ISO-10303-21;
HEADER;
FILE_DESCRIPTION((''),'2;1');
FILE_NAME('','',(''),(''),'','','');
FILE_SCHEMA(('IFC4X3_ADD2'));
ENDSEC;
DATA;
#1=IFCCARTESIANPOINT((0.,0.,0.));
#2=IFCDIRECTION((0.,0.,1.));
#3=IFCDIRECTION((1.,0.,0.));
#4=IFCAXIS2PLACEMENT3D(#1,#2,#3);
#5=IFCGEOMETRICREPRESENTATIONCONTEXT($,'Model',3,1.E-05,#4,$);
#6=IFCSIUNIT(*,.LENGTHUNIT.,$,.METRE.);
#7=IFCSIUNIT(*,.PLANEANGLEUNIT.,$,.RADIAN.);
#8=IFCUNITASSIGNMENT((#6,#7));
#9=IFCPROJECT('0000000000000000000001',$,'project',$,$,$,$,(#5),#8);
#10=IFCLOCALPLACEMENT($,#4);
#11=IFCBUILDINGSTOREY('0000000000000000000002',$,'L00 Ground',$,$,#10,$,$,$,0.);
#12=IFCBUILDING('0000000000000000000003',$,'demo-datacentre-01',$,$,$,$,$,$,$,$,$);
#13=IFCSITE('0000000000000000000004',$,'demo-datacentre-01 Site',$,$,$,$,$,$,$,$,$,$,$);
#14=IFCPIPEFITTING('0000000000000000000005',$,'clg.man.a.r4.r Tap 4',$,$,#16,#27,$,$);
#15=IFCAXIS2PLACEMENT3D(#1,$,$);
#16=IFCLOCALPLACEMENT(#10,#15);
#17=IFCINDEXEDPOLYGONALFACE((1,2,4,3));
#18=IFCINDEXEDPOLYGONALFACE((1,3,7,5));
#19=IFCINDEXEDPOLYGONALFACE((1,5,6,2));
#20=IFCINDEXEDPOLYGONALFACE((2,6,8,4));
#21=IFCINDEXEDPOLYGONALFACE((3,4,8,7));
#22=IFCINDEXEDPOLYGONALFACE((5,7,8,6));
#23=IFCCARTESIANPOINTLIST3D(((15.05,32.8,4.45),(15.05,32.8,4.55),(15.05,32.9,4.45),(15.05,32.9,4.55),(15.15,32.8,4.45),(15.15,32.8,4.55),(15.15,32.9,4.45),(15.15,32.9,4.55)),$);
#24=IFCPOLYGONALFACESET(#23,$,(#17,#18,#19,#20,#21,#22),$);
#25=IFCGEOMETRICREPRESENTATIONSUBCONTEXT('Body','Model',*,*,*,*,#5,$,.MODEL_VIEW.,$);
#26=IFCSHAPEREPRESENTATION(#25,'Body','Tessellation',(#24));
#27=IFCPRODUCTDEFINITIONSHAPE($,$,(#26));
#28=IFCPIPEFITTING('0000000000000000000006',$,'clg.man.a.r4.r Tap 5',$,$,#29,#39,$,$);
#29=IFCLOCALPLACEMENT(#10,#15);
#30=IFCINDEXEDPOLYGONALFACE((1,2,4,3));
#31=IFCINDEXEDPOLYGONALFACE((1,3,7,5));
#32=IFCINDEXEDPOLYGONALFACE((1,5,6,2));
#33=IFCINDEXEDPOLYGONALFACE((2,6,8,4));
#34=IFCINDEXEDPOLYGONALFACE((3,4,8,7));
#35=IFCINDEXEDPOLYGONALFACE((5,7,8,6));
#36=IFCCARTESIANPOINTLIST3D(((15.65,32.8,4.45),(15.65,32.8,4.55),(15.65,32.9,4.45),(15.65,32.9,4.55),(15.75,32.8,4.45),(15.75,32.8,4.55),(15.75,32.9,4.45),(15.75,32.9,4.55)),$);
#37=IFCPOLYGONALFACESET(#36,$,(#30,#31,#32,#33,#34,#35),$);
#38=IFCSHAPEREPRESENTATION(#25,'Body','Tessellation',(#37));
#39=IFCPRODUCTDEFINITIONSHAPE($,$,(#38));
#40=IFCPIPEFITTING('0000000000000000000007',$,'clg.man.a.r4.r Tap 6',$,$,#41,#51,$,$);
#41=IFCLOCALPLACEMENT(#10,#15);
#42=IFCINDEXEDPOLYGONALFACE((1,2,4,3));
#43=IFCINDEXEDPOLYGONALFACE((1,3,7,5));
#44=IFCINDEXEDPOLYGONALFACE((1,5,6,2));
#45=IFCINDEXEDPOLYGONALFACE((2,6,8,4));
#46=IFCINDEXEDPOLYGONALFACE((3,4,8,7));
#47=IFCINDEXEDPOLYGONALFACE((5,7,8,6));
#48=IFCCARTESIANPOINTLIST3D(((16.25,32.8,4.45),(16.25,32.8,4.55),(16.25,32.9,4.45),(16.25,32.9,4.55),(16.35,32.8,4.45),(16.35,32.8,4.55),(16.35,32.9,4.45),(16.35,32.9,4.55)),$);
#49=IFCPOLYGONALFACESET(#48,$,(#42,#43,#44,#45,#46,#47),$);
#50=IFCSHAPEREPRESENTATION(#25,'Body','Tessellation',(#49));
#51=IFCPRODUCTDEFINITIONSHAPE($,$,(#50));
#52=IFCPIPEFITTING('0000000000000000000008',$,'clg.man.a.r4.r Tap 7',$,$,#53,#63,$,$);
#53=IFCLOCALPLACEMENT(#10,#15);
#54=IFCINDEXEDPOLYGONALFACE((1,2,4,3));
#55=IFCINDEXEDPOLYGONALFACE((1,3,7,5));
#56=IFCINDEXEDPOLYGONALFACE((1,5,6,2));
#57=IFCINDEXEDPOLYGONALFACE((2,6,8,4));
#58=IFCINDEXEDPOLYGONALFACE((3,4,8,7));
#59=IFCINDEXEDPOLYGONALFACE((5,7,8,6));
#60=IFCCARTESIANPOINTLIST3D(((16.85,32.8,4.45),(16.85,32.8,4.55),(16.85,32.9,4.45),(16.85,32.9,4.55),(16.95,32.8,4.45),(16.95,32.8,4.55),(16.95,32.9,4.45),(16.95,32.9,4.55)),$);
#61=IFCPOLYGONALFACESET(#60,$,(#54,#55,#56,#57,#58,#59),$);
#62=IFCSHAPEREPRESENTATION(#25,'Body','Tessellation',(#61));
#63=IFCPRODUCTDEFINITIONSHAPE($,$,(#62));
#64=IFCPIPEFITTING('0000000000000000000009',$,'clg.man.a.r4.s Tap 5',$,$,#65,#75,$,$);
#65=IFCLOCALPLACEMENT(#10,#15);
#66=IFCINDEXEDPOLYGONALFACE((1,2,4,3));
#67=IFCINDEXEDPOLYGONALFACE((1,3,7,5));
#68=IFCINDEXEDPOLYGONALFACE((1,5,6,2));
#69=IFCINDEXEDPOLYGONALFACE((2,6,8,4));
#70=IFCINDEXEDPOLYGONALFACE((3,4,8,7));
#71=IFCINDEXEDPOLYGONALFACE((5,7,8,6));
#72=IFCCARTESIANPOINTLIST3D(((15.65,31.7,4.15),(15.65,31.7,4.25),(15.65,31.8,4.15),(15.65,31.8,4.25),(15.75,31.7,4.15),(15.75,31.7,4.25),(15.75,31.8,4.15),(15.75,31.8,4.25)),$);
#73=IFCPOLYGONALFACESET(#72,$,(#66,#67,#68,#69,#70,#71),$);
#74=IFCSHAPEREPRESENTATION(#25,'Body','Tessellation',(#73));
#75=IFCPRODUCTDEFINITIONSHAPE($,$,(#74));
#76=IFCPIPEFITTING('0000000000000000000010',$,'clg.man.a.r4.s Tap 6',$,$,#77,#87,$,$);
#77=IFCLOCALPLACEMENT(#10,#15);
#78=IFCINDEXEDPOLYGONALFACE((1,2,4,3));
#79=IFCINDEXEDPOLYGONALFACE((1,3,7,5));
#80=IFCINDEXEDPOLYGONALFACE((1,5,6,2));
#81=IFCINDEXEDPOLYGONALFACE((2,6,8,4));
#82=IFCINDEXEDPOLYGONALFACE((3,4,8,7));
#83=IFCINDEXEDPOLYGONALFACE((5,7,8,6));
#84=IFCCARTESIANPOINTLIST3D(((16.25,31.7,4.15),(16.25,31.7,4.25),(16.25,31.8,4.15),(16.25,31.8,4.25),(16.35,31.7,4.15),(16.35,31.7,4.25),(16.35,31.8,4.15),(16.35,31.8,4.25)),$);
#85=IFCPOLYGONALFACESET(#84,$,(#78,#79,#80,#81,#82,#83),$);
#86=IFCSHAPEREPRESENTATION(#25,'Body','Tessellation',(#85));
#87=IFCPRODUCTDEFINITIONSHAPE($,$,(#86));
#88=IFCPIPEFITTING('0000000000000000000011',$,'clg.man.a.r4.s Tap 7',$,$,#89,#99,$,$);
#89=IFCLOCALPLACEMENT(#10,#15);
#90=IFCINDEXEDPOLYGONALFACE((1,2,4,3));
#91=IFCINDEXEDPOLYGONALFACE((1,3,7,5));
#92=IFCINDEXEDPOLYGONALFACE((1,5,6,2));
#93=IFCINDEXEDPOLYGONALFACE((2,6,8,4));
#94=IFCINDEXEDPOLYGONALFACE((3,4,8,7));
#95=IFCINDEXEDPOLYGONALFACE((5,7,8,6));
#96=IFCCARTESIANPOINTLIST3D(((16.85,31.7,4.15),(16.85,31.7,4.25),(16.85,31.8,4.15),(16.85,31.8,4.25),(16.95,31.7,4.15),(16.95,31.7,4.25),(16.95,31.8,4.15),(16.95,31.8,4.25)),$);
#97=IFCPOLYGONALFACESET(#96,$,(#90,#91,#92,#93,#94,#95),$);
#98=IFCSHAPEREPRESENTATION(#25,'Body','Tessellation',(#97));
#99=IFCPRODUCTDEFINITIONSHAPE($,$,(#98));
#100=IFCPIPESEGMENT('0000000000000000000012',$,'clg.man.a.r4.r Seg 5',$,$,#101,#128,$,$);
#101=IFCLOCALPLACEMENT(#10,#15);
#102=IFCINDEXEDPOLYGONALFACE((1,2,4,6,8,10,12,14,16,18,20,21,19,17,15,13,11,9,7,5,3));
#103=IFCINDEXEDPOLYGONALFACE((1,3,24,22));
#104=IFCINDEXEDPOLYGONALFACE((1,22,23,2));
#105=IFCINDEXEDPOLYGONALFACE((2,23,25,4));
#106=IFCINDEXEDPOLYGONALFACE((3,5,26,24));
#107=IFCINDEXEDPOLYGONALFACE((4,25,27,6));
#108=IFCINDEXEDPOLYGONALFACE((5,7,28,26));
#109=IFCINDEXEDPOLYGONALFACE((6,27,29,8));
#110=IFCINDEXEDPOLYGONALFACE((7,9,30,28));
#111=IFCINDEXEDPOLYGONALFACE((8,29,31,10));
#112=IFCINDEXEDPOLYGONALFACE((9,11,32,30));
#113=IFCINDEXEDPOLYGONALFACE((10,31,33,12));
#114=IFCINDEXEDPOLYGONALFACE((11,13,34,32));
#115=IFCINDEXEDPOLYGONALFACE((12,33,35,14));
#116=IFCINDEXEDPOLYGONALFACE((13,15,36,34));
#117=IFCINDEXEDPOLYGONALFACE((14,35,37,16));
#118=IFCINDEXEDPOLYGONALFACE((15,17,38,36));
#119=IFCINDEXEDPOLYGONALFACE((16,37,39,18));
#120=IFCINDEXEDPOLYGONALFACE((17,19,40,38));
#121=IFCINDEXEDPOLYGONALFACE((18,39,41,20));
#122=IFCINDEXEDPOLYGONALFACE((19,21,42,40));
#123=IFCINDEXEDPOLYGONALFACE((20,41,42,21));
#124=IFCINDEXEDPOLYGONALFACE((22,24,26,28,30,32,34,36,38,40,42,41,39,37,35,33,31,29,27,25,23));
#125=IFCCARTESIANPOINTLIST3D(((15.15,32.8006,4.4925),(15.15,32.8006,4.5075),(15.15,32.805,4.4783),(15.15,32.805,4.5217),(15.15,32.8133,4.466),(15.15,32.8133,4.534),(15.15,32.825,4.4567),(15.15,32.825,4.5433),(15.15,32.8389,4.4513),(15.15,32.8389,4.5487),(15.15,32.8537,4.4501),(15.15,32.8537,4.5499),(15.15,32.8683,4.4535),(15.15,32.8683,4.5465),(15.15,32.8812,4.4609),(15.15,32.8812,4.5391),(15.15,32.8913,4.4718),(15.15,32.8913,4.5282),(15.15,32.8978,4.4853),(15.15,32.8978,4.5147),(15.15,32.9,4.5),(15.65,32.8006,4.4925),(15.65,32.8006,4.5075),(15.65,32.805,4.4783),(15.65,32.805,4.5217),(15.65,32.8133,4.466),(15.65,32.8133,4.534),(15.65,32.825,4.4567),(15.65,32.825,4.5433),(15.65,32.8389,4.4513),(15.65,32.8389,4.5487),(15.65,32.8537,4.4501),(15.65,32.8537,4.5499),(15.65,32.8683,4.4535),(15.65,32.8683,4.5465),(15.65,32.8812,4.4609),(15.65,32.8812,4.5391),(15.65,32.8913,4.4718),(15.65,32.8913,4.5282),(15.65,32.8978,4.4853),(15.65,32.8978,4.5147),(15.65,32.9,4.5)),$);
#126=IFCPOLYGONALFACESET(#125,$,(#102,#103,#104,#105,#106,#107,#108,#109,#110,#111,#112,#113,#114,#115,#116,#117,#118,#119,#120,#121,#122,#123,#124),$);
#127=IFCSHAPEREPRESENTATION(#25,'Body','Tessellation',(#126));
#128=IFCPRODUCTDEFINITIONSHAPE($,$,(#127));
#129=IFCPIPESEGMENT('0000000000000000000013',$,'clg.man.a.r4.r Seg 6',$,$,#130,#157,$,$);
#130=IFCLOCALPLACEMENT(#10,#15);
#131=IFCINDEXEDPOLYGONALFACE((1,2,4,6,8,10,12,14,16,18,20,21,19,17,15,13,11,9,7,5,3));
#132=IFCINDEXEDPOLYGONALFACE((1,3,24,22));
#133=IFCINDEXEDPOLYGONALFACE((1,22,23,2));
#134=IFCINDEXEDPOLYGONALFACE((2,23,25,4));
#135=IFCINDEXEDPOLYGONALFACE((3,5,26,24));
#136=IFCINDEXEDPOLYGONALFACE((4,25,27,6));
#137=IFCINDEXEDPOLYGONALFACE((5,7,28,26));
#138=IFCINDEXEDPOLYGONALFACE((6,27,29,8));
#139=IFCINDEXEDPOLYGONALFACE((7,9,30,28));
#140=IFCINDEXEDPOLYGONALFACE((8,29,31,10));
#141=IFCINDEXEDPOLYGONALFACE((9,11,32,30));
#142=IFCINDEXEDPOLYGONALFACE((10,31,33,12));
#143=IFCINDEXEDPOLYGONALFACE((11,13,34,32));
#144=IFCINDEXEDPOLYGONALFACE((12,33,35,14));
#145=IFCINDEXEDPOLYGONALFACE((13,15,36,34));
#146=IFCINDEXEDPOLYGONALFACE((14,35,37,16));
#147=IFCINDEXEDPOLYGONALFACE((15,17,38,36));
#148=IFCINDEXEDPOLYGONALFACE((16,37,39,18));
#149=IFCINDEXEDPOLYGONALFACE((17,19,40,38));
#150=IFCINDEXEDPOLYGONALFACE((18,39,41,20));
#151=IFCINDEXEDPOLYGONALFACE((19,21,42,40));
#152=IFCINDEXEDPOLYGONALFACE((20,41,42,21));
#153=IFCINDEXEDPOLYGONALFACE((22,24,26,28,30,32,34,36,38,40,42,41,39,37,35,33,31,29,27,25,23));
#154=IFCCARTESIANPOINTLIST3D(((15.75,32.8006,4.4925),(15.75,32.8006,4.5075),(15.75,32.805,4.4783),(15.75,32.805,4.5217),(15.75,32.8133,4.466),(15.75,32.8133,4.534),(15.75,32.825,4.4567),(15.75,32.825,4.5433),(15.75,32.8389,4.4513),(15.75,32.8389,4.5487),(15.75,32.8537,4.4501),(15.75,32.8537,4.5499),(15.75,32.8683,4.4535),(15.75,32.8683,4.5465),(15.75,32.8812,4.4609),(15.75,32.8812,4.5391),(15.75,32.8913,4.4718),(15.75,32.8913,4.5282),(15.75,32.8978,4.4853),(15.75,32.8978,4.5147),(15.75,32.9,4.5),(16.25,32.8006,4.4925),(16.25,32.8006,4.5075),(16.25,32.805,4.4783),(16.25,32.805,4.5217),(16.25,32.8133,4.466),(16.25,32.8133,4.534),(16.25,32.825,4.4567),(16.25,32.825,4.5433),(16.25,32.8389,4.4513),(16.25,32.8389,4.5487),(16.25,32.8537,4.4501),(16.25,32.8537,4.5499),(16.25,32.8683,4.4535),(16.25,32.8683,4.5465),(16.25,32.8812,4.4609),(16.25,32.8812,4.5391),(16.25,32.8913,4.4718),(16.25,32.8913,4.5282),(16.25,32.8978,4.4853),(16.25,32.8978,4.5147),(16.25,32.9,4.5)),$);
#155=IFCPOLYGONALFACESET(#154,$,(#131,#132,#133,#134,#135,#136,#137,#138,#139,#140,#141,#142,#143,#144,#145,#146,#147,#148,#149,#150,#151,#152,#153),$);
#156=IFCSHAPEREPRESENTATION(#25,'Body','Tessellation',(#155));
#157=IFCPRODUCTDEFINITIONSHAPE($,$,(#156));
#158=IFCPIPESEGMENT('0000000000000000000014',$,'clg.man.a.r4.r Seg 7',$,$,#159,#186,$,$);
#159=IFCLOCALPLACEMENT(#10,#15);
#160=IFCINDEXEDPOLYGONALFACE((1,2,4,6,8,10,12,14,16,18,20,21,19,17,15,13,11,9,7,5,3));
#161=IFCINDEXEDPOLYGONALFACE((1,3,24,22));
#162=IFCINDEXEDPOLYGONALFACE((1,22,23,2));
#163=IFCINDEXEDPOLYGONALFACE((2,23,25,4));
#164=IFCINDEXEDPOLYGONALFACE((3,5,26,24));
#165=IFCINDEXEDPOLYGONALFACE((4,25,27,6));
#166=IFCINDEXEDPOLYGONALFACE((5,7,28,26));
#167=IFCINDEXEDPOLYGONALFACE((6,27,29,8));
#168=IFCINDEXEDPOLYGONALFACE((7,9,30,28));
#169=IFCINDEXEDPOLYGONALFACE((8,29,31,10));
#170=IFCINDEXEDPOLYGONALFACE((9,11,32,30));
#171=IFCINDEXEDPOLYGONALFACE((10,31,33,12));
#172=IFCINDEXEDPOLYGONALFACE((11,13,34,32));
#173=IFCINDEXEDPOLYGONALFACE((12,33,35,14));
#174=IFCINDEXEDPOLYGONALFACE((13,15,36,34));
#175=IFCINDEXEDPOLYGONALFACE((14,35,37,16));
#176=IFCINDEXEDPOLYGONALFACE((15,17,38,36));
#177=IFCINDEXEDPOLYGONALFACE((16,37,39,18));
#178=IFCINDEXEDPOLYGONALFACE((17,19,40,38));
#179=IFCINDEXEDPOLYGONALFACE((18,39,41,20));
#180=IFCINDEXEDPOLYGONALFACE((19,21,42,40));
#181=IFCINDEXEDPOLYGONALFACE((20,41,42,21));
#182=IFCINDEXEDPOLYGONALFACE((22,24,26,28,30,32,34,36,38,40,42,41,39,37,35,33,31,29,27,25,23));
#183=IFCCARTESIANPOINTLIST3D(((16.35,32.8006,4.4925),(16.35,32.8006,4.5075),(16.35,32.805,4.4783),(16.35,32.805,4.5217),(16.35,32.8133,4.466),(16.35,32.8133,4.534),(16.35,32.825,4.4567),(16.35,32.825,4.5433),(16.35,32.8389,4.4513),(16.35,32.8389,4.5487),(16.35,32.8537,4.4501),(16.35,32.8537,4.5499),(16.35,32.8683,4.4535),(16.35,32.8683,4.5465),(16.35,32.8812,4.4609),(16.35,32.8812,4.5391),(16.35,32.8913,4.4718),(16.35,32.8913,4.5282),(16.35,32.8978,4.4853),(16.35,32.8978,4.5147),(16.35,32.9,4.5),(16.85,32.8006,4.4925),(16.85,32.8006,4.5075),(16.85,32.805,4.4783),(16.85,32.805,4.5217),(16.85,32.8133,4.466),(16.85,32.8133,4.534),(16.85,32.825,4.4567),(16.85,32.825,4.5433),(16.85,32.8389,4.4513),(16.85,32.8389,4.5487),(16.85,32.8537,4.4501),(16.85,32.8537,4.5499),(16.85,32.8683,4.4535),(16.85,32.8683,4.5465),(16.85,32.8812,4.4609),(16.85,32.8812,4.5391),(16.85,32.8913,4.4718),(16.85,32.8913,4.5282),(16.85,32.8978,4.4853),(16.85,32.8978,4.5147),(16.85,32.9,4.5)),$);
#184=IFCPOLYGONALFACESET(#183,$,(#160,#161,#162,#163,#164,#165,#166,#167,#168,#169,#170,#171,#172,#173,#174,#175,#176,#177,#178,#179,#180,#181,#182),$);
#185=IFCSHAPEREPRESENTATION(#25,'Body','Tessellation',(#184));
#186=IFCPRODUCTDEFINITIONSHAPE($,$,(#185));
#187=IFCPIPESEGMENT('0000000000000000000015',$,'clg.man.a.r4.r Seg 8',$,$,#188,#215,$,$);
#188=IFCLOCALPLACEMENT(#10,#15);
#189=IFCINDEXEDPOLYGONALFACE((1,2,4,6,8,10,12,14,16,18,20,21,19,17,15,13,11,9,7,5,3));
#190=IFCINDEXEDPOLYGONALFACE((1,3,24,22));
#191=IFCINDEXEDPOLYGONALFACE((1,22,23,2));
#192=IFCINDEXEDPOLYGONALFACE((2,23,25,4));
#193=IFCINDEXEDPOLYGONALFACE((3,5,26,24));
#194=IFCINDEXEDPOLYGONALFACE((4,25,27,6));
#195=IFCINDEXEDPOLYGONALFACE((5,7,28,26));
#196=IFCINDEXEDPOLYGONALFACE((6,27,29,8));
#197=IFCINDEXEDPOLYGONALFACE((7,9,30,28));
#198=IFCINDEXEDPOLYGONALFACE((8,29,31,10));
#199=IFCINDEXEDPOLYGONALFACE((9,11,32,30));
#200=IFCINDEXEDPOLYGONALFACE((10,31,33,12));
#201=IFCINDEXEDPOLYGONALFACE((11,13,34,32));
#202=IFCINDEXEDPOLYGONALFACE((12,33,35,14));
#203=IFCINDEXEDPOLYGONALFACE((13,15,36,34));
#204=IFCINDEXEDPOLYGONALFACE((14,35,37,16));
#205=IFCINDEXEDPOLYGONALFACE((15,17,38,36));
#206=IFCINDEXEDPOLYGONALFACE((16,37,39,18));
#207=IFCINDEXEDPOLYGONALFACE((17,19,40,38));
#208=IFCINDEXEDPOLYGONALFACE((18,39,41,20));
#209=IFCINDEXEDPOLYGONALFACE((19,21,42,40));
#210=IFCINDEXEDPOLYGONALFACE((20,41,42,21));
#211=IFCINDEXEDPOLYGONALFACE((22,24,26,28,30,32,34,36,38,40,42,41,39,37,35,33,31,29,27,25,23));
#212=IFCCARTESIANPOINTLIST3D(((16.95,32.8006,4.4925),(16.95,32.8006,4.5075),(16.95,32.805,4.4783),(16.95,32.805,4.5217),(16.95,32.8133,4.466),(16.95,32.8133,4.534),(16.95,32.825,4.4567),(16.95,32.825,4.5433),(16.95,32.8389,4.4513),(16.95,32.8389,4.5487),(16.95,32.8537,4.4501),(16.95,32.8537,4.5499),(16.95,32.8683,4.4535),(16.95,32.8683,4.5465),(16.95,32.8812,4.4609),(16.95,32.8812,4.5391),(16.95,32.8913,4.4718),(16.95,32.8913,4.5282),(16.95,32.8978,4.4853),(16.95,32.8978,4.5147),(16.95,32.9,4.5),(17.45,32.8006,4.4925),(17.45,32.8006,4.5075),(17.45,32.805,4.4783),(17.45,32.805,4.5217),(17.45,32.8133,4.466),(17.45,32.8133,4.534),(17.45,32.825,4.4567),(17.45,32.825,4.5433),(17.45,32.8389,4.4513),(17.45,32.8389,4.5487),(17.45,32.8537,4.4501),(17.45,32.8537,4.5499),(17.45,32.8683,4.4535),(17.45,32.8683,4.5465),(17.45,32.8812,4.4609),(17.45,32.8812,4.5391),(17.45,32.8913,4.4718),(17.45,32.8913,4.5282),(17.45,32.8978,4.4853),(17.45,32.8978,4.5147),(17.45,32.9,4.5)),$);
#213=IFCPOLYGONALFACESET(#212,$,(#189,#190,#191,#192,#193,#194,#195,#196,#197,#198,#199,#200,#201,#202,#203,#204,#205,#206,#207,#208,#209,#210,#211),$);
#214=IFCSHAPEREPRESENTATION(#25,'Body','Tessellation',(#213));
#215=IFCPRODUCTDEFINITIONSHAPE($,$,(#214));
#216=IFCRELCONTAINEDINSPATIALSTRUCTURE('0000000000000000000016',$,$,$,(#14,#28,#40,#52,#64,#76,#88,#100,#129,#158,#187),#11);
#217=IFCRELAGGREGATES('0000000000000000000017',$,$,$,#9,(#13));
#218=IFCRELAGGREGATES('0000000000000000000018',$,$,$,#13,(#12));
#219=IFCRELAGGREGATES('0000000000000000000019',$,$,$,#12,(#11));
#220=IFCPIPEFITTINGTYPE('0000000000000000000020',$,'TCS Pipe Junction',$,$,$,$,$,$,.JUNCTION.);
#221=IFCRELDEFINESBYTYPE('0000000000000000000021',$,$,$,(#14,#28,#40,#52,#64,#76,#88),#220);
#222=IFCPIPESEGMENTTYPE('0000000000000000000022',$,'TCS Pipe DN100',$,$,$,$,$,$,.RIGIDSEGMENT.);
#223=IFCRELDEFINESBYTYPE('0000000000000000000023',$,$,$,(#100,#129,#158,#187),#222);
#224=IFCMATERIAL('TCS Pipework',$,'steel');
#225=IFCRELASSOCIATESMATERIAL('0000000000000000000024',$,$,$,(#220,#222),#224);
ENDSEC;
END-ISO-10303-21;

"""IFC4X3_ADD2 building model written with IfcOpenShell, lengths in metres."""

from ifc_helpers import new_model, si_unit, frame, origin_with_axes, place, context, subcontext, project, spatial, rectangle, circle, extrude, material, type_object, element, save


model = new_model("IFC4X3_ADD2")

# Units and contexts
model_context = context("Model", 3, precision=1e-05, world=origin_with_axes())
body_context = subcontext(model_context, "Body", "Model", "MODEL_VIEW")
ifc_project = project(units=[si_unit("LENGTHUNIT", "METRE"), si_unit("PLANEANGLEUNIT", "RADIAN")], contexts=[model_context])

# Site, building, storey
site = spatial("IfcSite", under=ifc_project, Name="demo-datacentre-01 Site")
building = spatial("IfcBuilding", under=site, Name="demo-datacentre-01")
storey_placement = place(None, origin_with_axes())
storey = spatial("IfcBuildingStorey", under=building, at=storey_placement, Name="L00 Ground", Elevation=0.0)

# Pipe fittings
ifc_material = material(Name="TCS Pipework", Category="steel")
pipe_fitting_type = type_object("IfcPipeFittingType", Name="TCS Pipe Junction", PredefinedType="JUNCTION", material=ifc_material)
for number, where, z_axis, x_axis, name in (
    (1, (15.1, 32.85, 4.45), (0.0, 0.0, 1.0), (1.0, 0.0, 0.0), "clg.man.a.r4.r Tap 4"),
    (2, (15.7, 32.85, 4.45), (0.0, 0.0, 1.0), (1.0, 0.0, 0.0), "clg.man.a.r4.r Tap 5"),
    (3, (16.3, 32.85, 4.45), (0.0, 0.0, 1.0), (1.0, 0.0, 0.0), "clg.man.a.r4.r Tap 6"),
    (4, (16.9, 32.85, 4.45), (0.0, 0.0, 1.0), (1.0, 0.0, 0.0), "clg.man.a.r4.r Tap 7"),
    (5, (15.7, 31.75, 4.15), (0.0, 0.0, 1.0), (1.0, 0.0, 0.0), "clg.man.a.r4.s Tap 5"),
    (6, (16.3, 31.75, 4.15), (0.0, 0.0, 1.0), (1.0, 0.0, 0.0), "clg.man.a.r4.s Tap 6"),
    (7, (16.9, 31.75, 4.15), (0.0, 0.0, 1.0), (1.0, 0.0, 0.0), "clg.man.a.r4.s Tap 7"),
):
    element("IfcPipeFitting", number, at=place(storey_placement, frame(where, z_axis=z_axis, x_axis=x_axis)), inside=storey, type_object=pipe_fitting_type, Name=name, context=body_context, shape_type="SweptSolid", body=[
        extrude(rectangle(XDim=0.1, YDim=0.1), origin_with_axes(), (0.0, 0.0, 1.0), 0.1),
    ])

# Pipe segments
pipe_segment_type_1 = type_object("IfcPipeSegmentType", Name="TCS Pipe DN100", PredefinedType="RIGIDSEGMENT", material=ifc_material)
for number, where, z_axis, x_axis, name in (
    (8, (15.15, 32.85, 4.5), (1.0, 0.0, 0.0), (0.0, 1.0, 0.0), "clg.man.a.r4.r Seg 5"),
    (9, (15.75, 32.85, 4.5), (1.0, 0.0, 0.0), (0.0, 1.0, 0.0), "clg.man.a.r4.r Seg 6"),
):
    element("IfcPipeSegment", number, at=place(storey_placement, frame(where, z_axis=z_axis, x_axis=x_axis)), inside=storey, type_object=pipe_segment_type_1, Name=name, context=body_context, shape_type="SweptSolid", body=[
        extrude(circle(Radius=0.05), origin_with_axes(), (0.0, 0.0, 1.0), 0.5),
    ])
pipe_segment_1_placement = place(storey_placement, frame((16.35, 32.85, 4.5), z_axis=(1.0, 0.0, 0.0), x_axis=(0.0, 1.0, 0.0)))
element("IfcPipeSegment", 10, at=pipe_segment_1_placement, inside=storey, type_object=pipe_segment_type_1, Name="clg.man.a.r4.r Seg 7", context=body_context, shape_type="SweptSolid", body=[
    extrude(circle(Radius=0.05), origin_with_axes(), (0.0, 0.0, 1.0), 0.5),
])
pipe_segment_2_placement = place(storey_placement, frame((16.95, 32.85, 4.5), z_axis=(1.0, 0.0, 0.0), x_axis=(0.0, 1.0, 0.0)))
element("IfcPipeSegment", 11, at=pipe_segment_2_placement, inside=storey, type_object=pipe_segment_type_1, Name="clg.man.a.r4.r Seg 8", context=body_context, shape_type="SweptSolid", body=[
    extrude(circle(Radius=0.05), origin_with_axes(), (0.0, 0.0, 1.0), 0.5),
])

save(model, "model.ifc")
